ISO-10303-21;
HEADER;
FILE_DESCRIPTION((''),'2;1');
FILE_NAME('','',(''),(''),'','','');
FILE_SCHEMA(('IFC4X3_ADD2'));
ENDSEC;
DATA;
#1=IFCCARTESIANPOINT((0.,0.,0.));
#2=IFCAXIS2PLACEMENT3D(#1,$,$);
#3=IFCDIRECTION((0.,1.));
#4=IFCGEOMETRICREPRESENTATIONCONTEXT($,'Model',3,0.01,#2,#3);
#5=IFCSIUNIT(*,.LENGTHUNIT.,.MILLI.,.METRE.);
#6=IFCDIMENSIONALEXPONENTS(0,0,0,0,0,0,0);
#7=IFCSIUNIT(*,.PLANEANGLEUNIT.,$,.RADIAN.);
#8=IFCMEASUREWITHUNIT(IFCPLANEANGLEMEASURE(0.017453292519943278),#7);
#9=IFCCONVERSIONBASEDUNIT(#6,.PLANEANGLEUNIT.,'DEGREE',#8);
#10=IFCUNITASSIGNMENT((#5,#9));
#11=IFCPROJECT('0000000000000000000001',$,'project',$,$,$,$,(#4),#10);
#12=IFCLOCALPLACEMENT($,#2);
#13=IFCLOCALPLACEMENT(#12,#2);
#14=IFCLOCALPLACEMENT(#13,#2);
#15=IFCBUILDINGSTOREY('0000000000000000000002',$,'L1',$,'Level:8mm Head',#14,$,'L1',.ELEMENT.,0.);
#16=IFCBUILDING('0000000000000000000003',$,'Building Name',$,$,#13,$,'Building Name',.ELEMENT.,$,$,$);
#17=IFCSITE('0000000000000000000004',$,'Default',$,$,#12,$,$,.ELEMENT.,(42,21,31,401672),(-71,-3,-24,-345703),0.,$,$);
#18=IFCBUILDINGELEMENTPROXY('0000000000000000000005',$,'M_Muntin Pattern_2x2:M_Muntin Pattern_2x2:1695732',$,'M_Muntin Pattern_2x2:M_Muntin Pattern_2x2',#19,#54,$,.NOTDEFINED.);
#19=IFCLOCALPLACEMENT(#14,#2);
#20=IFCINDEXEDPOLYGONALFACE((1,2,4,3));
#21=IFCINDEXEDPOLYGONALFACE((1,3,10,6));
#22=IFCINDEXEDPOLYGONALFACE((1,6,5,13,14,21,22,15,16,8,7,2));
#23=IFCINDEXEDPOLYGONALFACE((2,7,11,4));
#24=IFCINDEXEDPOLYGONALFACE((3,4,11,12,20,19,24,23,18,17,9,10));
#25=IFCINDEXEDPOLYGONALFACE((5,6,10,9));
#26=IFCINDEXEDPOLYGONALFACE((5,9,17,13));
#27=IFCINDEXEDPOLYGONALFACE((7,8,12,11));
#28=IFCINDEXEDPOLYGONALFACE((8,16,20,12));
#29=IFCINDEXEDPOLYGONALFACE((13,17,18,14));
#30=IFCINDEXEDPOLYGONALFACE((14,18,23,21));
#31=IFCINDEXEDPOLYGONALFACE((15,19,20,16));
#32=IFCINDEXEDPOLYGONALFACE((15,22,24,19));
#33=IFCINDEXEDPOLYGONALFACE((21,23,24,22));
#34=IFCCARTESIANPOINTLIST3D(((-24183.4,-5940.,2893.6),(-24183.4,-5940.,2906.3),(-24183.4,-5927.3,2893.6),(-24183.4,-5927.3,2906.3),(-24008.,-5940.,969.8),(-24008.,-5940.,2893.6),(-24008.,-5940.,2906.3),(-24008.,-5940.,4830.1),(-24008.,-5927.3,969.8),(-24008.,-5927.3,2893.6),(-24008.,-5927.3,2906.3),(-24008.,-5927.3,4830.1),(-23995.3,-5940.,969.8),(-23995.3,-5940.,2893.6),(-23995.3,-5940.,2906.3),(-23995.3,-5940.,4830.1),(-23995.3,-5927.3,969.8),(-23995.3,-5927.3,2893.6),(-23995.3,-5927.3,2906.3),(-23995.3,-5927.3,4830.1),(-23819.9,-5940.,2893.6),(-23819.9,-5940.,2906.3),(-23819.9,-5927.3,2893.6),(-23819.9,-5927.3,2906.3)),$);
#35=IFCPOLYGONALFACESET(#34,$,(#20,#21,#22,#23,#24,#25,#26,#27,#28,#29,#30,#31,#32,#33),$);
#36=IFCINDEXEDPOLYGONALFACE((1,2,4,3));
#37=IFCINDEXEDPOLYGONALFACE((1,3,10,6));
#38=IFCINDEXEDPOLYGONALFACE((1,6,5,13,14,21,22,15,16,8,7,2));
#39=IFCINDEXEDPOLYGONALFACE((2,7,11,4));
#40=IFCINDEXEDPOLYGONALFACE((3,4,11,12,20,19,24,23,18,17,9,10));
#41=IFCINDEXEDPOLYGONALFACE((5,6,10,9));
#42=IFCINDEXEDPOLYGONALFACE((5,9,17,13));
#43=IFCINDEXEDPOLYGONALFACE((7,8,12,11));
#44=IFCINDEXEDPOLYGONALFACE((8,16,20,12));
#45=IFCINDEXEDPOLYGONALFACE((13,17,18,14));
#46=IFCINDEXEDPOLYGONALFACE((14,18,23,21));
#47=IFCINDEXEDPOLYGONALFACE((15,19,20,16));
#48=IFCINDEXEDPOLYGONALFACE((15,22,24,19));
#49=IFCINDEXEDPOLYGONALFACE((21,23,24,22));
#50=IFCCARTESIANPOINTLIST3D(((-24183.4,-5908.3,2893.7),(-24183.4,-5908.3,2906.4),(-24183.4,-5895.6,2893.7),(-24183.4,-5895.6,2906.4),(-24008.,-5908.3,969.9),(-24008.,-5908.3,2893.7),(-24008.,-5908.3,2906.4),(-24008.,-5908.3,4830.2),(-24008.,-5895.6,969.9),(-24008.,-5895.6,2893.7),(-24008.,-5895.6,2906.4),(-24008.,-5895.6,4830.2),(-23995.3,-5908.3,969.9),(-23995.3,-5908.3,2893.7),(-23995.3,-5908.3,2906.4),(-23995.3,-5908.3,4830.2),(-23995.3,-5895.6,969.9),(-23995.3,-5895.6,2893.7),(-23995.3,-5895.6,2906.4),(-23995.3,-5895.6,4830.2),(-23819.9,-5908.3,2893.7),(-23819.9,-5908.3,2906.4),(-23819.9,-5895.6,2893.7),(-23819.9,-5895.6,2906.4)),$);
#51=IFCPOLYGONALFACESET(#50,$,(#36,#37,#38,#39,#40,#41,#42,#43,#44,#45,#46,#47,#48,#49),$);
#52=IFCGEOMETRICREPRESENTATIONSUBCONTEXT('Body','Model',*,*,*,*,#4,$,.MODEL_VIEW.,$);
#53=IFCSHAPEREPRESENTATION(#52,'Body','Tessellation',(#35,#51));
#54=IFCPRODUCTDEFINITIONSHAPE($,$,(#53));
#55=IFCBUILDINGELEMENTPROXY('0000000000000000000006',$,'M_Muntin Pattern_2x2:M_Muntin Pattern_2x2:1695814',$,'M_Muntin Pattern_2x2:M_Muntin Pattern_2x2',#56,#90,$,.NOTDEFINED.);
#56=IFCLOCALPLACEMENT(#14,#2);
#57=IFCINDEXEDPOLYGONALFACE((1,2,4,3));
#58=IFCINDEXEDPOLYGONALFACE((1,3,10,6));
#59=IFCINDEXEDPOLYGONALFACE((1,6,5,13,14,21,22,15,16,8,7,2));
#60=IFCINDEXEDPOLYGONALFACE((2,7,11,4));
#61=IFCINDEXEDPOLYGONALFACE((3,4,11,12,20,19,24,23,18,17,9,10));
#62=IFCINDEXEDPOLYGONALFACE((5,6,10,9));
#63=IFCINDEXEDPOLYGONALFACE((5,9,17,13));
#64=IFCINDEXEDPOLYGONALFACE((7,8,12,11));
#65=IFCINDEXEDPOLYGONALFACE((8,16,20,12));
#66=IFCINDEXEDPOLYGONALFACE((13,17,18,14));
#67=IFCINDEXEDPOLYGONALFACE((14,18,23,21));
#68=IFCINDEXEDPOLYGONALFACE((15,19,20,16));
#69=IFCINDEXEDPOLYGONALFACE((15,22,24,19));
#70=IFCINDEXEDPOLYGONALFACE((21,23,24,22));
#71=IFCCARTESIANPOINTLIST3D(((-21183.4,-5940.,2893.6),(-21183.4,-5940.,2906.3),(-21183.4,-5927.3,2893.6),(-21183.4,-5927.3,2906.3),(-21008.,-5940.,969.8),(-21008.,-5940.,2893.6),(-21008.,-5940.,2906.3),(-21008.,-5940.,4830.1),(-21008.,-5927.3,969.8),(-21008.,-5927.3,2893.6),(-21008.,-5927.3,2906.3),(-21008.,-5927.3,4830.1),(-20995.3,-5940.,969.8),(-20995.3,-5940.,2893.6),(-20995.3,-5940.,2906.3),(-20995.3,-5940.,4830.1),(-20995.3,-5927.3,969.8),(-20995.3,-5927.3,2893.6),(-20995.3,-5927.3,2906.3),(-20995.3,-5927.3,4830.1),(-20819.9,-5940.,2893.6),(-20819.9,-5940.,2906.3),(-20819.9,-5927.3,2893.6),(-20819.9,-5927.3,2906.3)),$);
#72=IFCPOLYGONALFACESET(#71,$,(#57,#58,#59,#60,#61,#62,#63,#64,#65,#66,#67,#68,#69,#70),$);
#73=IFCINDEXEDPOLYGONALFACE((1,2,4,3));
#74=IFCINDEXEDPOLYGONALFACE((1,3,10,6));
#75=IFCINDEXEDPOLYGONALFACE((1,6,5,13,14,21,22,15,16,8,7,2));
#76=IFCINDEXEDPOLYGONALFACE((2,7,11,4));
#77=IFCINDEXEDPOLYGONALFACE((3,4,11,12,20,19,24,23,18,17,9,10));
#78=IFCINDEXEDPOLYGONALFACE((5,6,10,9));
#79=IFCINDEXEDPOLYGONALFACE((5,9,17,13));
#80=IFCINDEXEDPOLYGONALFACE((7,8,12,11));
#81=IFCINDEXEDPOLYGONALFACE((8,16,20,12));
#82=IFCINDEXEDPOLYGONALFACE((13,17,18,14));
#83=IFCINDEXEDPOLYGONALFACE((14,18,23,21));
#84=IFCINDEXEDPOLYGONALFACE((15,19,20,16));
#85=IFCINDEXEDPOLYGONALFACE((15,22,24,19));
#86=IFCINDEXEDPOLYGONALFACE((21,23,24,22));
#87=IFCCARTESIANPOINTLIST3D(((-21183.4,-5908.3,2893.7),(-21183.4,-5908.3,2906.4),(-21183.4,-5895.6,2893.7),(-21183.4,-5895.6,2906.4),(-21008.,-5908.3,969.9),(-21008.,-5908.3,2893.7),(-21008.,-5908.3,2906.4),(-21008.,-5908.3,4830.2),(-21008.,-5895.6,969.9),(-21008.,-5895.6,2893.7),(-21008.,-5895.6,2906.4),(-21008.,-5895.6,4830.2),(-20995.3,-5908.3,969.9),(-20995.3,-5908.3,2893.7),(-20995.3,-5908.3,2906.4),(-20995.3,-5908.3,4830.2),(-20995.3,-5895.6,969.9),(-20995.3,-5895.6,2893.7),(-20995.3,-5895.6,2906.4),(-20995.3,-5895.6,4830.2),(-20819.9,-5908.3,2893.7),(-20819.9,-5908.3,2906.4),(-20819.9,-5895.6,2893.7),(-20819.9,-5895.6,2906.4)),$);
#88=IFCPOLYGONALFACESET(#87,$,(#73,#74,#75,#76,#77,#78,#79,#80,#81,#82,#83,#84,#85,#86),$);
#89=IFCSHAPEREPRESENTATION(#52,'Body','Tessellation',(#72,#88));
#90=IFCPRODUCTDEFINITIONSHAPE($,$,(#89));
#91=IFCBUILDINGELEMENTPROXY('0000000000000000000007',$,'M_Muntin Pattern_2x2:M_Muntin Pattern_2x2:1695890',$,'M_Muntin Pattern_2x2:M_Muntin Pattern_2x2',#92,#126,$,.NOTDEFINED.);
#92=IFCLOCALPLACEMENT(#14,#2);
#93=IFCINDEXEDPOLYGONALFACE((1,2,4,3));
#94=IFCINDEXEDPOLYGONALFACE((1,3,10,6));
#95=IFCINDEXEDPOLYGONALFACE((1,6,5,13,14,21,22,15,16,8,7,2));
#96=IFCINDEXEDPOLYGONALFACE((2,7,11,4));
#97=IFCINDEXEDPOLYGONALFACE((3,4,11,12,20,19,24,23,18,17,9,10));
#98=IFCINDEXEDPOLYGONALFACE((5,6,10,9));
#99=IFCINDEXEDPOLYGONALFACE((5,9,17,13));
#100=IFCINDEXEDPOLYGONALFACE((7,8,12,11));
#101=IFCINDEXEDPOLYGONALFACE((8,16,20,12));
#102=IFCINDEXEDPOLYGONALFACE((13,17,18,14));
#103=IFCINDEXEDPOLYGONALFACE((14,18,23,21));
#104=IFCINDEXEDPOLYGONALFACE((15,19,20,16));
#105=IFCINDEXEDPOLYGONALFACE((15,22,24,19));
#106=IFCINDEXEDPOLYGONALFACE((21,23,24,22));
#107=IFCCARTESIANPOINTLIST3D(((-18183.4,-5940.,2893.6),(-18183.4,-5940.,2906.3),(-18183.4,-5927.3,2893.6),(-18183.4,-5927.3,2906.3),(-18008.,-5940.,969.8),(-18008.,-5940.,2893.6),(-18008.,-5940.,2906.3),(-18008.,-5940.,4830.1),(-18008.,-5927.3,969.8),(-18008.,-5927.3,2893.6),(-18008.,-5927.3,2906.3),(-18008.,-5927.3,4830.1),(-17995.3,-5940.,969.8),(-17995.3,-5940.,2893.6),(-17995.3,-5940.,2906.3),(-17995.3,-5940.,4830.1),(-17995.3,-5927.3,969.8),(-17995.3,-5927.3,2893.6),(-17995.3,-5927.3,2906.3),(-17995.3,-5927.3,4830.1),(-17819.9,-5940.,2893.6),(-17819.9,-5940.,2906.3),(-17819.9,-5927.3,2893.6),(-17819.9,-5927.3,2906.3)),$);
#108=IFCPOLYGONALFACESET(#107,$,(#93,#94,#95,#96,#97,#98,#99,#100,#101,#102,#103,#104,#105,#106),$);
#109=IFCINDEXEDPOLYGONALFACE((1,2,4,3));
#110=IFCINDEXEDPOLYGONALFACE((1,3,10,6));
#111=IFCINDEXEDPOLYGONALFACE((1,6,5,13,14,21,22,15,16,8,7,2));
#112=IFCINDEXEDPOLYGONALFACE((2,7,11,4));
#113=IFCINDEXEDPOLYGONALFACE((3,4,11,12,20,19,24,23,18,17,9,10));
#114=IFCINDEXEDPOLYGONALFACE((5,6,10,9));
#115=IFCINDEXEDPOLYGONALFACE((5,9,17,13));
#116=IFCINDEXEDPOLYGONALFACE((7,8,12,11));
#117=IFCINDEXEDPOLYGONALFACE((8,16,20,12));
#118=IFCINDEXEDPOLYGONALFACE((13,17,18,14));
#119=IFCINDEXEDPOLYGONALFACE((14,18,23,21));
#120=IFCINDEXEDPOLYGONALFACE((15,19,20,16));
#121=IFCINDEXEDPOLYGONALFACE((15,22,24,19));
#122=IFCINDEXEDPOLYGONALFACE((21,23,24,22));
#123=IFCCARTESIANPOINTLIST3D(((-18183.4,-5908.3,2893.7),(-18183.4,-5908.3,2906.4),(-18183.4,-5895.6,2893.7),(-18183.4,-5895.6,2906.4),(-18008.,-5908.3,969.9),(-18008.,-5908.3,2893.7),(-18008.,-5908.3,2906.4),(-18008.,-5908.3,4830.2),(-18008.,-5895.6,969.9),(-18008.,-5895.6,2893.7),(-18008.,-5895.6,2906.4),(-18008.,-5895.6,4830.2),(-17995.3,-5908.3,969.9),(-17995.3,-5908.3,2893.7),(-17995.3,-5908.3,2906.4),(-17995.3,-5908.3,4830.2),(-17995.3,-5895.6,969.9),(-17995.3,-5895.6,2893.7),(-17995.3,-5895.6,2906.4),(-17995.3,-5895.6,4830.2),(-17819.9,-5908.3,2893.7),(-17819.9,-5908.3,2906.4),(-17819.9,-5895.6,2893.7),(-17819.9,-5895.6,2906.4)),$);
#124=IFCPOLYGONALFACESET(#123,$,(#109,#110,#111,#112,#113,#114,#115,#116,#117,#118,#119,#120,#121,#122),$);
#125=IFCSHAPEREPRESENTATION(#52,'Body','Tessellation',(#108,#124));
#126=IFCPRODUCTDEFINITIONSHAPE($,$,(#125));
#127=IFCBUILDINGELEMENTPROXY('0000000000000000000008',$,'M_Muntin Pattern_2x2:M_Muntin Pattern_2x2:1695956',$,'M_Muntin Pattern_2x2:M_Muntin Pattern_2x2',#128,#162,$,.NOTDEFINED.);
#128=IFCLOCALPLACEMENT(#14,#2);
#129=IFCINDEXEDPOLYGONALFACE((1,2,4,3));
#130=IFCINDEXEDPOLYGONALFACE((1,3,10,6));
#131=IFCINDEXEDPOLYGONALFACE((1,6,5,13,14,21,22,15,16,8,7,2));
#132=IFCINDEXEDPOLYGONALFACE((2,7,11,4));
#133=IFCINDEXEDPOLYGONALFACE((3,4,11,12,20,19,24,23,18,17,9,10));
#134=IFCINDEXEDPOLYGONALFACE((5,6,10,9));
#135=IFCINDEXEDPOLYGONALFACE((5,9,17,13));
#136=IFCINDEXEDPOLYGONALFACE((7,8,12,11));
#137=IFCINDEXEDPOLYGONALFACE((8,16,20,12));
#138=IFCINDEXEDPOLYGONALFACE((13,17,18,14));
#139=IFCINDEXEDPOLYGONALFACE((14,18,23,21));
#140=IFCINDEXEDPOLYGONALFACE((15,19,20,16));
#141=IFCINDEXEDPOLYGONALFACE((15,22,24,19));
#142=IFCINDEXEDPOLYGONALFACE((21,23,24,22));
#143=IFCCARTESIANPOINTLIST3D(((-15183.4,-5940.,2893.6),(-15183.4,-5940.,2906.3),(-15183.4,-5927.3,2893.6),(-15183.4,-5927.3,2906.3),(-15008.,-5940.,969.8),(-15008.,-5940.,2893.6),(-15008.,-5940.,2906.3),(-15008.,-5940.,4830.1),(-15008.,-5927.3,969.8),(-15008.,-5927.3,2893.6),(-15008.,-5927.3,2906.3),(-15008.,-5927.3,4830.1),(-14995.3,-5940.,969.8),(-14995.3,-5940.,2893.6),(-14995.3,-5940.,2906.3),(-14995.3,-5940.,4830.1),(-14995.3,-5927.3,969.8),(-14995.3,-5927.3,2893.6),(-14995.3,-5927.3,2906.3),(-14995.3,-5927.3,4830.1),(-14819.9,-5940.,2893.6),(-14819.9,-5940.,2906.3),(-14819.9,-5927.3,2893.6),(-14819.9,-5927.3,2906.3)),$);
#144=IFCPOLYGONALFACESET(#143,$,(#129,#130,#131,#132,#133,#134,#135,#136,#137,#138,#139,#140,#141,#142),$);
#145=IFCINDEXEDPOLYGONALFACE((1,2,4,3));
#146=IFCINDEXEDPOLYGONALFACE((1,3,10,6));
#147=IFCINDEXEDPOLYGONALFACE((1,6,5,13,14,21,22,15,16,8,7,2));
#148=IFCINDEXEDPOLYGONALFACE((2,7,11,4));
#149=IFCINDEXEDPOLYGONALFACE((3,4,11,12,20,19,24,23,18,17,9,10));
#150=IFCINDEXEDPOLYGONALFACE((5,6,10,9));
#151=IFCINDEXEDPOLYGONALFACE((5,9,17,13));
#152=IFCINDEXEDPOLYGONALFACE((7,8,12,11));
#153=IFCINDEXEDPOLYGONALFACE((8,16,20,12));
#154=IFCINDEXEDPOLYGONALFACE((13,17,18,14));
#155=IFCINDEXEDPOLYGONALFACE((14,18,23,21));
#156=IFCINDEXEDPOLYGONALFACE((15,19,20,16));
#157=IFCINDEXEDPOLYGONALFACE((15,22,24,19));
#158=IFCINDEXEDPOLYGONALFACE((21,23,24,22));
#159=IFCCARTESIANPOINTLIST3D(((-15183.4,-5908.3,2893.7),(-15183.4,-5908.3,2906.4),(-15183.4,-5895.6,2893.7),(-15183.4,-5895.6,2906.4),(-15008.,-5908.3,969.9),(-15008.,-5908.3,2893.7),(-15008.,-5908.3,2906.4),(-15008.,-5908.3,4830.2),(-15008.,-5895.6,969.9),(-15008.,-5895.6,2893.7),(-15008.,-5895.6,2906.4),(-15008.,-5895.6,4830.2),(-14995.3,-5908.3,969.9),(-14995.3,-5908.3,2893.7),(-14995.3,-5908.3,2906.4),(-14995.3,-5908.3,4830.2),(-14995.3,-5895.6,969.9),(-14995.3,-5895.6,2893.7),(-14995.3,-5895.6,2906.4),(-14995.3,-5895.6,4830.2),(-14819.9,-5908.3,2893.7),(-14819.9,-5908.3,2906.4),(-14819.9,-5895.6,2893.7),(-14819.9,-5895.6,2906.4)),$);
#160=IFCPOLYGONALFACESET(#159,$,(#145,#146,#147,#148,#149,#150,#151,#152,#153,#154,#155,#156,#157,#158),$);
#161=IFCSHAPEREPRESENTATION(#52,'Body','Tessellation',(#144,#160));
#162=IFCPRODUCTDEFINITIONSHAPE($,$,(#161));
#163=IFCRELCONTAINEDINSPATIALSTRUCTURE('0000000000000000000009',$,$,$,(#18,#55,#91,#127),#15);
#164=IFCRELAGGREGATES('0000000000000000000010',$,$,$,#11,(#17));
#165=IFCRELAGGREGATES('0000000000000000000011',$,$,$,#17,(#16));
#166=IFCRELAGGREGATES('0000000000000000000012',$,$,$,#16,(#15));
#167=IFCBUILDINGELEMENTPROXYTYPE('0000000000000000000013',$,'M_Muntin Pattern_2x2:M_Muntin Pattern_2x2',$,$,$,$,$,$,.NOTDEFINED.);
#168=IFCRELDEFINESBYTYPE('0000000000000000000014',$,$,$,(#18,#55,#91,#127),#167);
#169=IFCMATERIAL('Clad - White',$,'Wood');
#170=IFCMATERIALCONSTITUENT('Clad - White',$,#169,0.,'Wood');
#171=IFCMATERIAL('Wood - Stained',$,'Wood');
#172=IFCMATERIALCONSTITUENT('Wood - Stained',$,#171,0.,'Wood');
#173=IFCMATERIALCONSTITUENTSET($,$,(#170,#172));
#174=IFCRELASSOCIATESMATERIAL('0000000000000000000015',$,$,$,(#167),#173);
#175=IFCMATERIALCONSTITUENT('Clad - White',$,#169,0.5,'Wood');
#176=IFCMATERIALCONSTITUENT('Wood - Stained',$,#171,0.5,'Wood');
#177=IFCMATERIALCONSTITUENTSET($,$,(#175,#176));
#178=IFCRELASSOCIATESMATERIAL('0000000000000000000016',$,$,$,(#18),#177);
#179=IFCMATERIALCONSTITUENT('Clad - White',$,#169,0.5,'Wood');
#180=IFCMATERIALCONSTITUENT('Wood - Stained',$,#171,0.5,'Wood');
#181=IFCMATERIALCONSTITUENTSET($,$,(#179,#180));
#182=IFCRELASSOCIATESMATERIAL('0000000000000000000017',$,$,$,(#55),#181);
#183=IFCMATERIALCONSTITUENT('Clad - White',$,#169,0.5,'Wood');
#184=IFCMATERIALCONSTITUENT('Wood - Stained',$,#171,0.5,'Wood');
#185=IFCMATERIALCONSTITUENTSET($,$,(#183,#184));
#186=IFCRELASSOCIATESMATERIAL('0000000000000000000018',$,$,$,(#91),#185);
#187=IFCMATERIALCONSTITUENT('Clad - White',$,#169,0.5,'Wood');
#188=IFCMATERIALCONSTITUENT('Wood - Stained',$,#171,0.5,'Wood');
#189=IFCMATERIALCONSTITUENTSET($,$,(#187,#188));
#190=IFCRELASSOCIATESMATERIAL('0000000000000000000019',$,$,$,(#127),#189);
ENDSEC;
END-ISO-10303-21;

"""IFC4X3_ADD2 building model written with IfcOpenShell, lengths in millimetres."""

from ifc_helpers import new_model, entity, si_unit, converted_unit, direction, frame, origin, place, context, subcontext, project, spatial, polyline, outline, extrude, source, transform, mapped, material, constituent, constituent_set, type_object, type_shapes, element, save


model = new_model("IFC4X3_ADD2")

# Units and contexts
model_context = context("Model", 3, precision=0.01, world=origin(), true_north=direction((0.0, 1.0)))
body_context = subcontext(model_context, "Body", "Model", "MODEL_VIEW")
ifc_project = project(units=[si_unit("LENGTHUNIT", "METRE", prefix="MILLI"), converted_unit("PLANEANGLEUNIT", "DEGREE", entity("IfcPlaneAngleMeasure", 0.017453292519943278), si_unit("PLANEANGLEUNIT", "RADIAN"), dimensions=[0, 0, 0, 0, 0, 0, 0])], contexts=[model_context])

# Site, building, storey
site_placement = place(None, origin())
site = spatial("IfcSite", under=ifc_project, at=site_placement, Name="Default", CompositionType="ELEMENT", RefLatitude=(42, 21, 31, 401672), RefLongitude=(-71, -3, -24, -345703), RefElevation=0.0)
building_placement = place(site_placement, origin())
building = spatial("IfcBuilding", under=site, at=building_placement, Name="Building Name", LongName="Building Name", CompositionType="ELEMENT")
storey_placement = place(building_placement, origin())
storey = spatial("IfcBuildingStorey", under=building, at=storey_placement, Name="L1", ObjectType="Level:8mm Head", LongName="L1", CompositionType="ELEMENT", Elevation=0.0)

# Building element proxies
ifc_material_1 = material(Name="Clad - White", Category="Wood")
ifc_material_2 = material(Name="Wood - Stained", Category="Wood")
ifc_constituent_1 = constituent(ifc_material_1, Name="Clad - White", Category="Wood", fraction=0.5)
ifc_constituent_2 = constituent(ifc_material_2, Name="Wood - Stained", Category="Wood", fraction=0.5)
ifc_constituent_set_1 = constituent_set(constituents=[ifc_constituent_1, ifc_constituent_2])
ifc_constituent_3 = constituent(ifc_material_1, Name="Clad - White", Category="Wood", fraction=0.0)
ifc_constituent_4 = constituent(ifc_material_2, Name="Wood - Stained", Category="Wood", fraction=0.0)
ifc_constituent_set_2 = constituent_set(constituents=[ifc_constituent_3, ifc_constituent_4])
building_element_proxy_type_1 = type_object("IfcBuildingElementProxyType", Name="M_Muntin Pattern_2x2:M_Muntin Pattern_2x2", PredefinedType="NOTDEFINED", material=ifc_constituent_set_2)
shared_shape_1 = source(origin(), body_context, "Body", "SweptSolid", [
    extrude(outline(polyline([(6.4, -6.4), (1930.1, -6.4), (1930.1, 6.3), (6.4, 6.3), (6.4, 181.7), (-6.3, 181.7), (-6.3, 6.3), (-1930.2, 6.3), (-1930.2, -6.4), (-6.3, -6.4), (-6.3, -181.7), (6.4, -181.7), (6.4, -6.4)])), frame((0.0, -22.2, 1930.1), z_axis=(0.0, 1.0, 0.0), x_axis=(0.0, 0.0, 1.0)), (0.0, 0.0, 1.0), 12.7),
    extrude(outline(polyline([(6.4, -6.4), (1930.2, -6.4), (1930.2, 6.3), (6.4, 6.3), (6.4, 181.7), (-6.3, 181.7), (-6.3, 6.3), (-1930.2, 6.3), (-1930.2, -6.4), (-6.3, -6.4), (-6.3, -181.7), (6.4, -181.7), (6.4, -6.4)])), frame((0.0, 9.5, 1930.2), z_axis=(0.0, 1.0, 0.0), x_axis=(0.0, 0.0, 1.0)), (0.0, 0.0, 1.0), 12.7),
])
type_shapes(building_element_proxy_type_1, [shared_shape_1])
proxy_1_placement = place(storey_placement, frame((-24001.6, -5917.8, 969.9)))
element("IfcBuildingElementProxy", 1, at=proxy_1_placement, inside=storey, type_object=building_element_proxy_type_1, material=ifc_constituent_set_1, Name="M_Muntin Pattern_2x2:M_Muntin Pattern_2x2:1695732", ObjectType="M_Muntin Pattern_2x2:M_Muntin Pattern_2x2", PredefinedType="NOTDEFINED", context=body_context, shape_type="MappedRepresentation", body=[
    mapped(shared_shape_1, transform((0.0, 0.0, 0.0), scale=1.0)),
])
ifc_constituent_5 = constituent(ifc_material_1, Name="Clad - White", Category="Wood", fraction=0.5)
ifc_constituent_6 = constituent(ifc_material_2, Name="Wood - Stained", Category="Wood", fraction=0.5)
ifc_constituent_set_3 = constituent_set(constituents=[ifc_constituent_5, ifc_constituent_6])
proxy_2_placement = place(storey_placement, frame((-21001.6, -5917.8, 969.9)))
element("IfcBuildingElementProxy", 2, at=proxy_2_placement, inside=storey, type_object=building_element_proxy_type_1, material=ifc_constituent_set_3, Name="M_Muntin Pattern_2x2:M_Muntin Pattern_2x2:1695814", ObjectType="M_Muntin Pattern_2x2:M_Muntin Pattern_2x2", PredefinedType="NOTDEFINED", context=body_context, shape_type="MappedRepresentation", body=[
    mapped(shared_shape_1, transform((0.0, 0.0, 0.0), scale=1.0)),
])
ifc_constituent_7 = constituent(ifc_material_1, Name="Clad - White", Category="Wood", fraction=0.5)
ifc_constituent_8 = constituent(ifc_material_2, Name="Wood - Stained", Category="Wood", fraction=0.5)
ifc_constituent_set_4 = constituent_set(constituents=[ifc_constituent_7, ifc_constituent_8])
proxy_3_placement = place(storey_placement, frame((-18001.6, -5917.8, 969.9)))
element("IfcBuildingElementProxy", 3, at=proxy_3_placement, inside=storey, type_object=building_element_proxy_type_1, material=ifc_constituent_set_4, Name="M_Muntin Pattern_2x2:M_Muntin Pattern_2x2:1695890", ObjectType="M_Muntin Pattern_2x2:M_Muntin Pattern_2x2", PredefinedType="NOTDEFINED", context=body_context, shape_type="MappedRepresentation", body=[
    mapped(shared_shape_1, transform((0.0, 0.0, 0.0), scale=1.0)),
])
ifc_constituent_9 = constituent(ifc_material_1, Name="Clad - White", Category="Wood", fraction=0.5)
ifc_constituent_10 = constituent(ifc_material_2, Name="Wood - Stained", Category="Wood", fraction=0.5)
ifc_constituent_set_5 = constituent_set(constituents=[ifc_constituent_9, ifc_constituent_10])
proxy_4_placement = place(storey_placement, frame((-15001.6, -5917.8, 969.9)))
element("IfcBuildingElementProxy", 4, at=proxy_4_placement, inside=storey, type_object=building_element_proxy_type_1, material=ifc_constituent_set_5, Name="M_Muntin Pattern_2x2:M_Muntin Pattern_2x2:1695956", ObjectType="M_Muntin Pattern_2x2:M_Muntin Pattern_2x2", PredefinedType="NOTDEFINED", context=body_context, shape_type="MappedRepresentation", body=[
    mapped(shared_shape_1, transform((0.0, 0.0, 0.0), scale=1.0)),
])

save(model, "model.ifc")
